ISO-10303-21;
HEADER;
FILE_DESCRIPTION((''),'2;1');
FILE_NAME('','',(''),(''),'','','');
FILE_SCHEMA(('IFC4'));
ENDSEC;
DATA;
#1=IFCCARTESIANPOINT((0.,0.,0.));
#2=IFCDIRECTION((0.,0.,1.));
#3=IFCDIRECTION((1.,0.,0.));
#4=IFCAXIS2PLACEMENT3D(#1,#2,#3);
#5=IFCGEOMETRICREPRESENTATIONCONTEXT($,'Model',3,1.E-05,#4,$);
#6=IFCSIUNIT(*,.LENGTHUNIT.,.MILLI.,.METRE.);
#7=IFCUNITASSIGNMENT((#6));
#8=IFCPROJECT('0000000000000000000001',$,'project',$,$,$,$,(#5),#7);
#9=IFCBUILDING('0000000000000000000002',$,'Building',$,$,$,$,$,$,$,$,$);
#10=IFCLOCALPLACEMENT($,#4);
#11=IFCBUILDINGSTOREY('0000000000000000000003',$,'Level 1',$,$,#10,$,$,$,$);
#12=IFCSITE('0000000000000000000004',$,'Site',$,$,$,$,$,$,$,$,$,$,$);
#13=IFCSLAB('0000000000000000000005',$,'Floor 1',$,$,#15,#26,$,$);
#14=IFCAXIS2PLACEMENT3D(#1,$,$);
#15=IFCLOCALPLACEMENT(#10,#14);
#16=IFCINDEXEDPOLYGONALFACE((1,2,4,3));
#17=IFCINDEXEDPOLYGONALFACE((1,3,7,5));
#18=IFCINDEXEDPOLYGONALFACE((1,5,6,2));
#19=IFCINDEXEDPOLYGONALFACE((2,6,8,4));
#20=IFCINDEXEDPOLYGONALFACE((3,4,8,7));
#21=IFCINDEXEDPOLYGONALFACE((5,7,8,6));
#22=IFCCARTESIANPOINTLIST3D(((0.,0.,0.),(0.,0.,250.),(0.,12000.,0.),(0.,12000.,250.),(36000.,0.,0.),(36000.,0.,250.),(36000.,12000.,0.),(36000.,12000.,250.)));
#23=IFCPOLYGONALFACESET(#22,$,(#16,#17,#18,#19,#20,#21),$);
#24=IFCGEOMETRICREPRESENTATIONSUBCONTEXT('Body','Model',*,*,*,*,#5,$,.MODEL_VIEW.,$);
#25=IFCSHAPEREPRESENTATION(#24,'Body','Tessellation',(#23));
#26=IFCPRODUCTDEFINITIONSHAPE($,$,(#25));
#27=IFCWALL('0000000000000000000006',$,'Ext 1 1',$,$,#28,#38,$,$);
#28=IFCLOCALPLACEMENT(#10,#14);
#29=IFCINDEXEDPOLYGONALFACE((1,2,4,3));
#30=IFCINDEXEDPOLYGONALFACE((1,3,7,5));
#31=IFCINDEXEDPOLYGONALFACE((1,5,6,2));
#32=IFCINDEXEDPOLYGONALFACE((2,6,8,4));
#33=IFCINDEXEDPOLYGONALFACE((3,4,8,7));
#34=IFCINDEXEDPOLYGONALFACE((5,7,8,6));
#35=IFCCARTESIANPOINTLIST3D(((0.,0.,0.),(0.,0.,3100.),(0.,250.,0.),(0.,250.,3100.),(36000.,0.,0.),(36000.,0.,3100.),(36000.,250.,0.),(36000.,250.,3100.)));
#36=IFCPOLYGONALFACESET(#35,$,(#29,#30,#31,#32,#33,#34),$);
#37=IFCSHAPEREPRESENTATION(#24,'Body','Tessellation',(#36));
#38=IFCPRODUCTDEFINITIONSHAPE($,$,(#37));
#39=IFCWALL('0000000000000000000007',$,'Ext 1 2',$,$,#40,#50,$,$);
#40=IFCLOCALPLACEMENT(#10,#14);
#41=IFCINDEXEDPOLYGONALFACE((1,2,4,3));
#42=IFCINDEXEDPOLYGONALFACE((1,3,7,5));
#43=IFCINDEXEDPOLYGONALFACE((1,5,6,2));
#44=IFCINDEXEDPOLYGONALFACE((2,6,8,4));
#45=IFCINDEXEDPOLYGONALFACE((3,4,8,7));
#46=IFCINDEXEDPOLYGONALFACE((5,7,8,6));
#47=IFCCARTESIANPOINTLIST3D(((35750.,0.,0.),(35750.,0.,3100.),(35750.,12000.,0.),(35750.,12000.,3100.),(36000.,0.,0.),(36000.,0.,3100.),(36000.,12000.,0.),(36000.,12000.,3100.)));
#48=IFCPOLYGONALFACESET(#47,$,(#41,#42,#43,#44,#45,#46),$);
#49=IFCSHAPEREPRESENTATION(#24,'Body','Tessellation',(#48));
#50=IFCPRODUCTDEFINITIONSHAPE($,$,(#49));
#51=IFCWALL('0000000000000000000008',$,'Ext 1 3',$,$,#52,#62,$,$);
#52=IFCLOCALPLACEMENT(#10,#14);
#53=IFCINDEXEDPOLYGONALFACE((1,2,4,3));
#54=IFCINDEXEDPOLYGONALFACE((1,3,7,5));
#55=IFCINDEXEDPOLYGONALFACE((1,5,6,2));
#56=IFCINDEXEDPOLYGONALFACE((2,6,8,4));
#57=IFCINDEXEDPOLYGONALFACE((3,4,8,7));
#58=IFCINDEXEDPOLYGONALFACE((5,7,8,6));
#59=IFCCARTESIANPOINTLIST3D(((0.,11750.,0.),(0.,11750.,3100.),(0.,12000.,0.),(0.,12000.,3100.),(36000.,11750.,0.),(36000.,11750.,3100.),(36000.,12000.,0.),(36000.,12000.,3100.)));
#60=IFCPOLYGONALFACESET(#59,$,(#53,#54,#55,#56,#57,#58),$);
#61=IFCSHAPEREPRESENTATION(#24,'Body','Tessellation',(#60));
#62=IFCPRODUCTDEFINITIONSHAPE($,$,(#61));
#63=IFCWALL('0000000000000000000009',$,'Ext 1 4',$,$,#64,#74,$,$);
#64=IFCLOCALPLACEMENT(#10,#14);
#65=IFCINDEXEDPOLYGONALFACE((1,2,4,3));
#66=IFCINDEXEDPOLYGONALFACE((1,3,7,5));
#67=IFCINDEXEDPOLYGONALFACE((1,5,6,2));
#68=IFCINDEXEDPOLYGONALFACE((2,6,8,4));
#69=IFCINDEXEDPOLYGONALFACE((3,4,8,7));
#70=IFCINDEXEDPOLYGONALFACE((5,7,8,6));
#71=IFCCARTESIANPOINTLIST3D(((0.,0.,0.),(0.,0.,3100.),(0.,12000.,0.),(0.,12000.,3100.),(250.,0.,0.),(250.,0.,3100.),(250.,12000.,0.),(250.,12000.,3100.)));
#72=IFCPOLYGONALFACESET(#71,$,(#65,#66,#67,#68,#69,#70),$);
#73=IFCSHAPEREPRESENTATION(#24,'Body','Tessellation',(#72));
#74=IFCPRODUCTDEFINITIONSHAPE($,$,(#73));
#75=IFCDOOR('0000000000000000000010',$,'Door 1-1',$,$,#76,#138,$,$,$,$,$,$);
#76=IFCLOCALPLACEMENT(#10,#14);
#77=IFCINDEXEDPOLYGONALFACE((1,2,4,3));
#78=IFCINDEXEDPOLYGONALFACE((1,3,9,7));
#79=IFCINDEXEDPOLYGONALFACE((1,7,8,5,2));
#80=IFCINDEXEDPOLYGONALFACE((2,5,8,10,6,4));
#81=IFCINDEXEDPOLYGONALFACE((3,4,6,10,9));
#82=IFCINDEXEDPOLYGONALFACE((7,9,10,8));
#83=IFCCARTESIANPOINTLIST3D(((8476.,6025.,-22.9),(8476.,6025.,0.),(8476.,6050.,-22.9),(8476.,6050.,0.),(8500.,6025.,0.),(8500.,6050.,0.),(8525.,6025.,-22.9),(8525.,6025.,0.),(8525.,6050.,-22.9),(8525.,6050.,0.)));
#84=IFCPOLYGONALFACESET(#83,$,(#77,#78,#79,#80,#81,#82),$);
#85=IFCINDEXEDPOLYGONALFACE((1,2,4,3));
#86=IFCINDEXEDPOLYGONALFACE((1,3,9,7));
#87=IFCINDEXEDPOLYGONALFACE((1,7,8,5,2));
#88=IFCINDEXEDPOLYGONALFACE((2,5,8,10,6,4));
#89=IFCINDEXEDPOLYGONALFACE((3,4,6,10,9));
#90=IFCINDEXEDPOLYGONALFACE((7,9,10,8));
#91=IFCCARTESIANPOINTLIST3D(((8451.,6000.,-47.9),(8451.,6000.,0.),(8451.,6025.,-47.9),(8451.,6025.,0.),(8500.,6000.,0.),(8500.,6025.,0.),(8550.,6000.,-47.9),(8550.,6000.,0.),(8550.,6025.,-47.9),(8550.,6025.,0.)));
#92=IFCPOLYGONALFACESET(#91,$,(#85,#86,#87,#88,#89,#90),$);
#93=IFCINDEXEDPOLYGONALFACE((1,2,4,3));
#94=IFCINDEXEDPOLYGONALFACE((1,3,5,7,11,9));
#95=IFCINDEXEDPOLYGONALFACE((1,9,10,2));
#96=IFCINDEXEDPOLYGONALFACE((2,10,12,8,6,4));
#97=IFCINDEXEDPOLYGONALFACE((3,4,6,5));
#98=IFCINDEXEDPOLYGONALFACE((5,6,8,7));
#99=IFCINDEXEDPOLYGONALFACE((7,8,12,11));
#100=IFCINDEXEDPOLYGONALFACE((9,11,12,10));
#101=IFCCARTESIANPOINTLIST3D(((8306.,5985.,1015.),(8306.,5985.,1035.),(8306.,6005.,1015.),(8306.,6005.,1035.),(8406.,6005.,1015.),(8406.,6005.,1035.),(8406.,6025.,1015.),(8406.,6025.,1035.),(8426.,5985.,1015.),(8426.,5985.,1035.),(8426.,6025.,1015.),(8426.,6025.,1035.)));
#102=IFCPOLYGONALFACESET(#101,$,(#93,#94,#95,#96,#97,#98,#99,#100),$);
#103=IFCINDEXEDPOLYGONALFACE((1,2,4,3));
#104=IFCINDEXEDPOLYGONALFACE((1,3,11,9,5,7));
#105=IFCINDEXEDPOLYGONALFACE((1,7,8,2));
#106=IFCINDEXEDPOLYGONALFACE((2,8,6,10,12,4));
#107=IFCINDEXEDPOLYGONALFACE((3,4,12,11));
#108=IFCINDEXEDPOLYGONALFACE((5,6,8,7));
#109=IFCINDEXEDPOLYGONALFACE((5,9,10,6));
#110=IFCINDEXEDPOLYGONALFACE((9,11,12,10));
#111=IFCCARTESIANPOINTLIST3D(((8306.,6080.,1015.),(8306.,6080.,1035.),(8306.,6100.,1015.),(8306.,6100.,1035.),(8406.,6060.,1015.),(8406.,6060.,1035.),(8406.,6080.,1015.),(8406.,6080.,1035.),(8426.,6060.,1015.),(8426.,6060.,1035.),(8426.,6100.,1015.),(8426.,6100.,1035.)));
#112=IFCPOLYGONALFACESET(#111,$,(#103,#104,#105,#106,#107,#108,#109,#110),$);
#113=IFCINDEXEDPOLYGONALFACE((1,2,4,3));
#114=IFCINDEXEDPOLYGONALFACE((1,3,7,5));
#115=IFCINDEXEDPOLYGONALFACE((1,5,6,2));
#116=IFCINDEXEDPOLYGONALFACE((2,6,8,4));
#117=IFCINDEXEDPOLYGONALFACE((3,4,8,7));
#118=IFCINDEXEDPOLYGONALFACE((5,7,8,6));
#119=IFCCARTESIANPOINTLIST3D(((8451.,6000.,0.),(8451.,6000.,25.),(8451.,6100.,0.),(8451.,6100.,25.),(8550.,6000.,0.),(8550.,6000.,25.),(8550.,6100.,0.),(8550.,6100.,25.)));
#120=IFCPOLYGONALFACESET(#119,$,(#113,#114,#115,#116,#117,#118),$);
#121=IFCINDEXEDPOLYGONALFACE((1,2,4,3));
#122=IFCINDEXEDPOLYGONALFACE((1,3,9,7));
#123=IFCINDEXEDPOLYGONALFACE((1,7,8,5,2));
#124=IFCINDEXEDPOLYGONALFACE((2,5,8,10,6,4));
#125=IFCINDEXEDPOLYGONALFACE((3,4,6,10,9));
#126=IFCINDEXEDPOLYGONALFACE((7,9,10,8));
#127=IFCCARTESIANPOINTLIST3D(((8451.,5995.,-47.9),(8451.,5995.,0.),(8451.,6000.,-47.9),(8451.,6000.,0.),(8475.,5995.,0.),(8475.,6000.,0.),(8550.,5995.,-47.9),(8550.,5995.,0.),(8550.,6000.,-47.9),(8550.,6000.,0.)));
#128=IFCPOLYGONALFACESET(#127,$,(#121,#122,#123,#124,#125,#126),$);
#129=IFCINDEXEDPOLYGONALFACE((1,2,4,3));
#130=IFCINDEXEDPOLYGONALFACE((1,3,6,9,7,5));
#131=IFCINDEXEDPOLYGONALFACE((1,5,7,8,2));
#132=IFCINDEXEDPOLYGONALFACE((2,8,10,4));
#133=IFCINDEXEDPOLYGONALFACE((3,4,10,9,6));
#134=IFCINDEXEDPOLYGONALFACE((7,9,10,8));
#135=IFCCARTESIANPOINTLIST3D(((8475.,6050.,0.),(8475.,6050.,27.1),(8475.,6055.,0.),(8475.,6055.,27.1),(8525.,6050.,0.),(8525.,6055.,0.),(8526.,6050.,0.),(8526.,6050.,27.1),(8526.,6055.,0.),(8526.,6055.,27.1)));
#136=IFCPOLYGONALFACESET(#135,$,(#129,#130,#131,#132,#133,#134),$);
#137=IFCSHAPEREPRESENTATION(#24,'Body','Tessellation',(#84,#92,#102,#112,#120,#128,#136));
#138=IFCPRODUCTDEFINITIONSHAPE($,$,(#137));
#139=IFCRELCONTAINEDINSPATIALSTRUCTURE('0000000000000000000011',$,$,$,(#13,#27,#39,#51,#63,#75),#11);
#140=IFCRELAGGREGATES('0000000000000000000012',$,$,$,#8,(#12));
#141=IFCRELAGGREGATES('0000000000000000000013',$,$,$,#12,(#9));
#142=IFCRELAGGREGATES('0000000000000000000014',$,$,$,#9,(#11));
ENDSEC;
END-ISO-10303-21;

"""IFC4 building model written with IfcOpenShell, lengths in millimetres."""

from ifc_helpers import new_model, si_unit, frame, origin_with_axes, place, context, subcontext, project, spatial, line, indexed_curve, outline, extrude, element, save


model = new_model("IFC4")

# Units and contexts
model_context = context("Model", 3, precision=1e-05, world=origin_with_axes())
body_context = subcontext(model_context, "Body", "Model", "MODEL_VIEW")
ifc_project = project(units=[si_unit("LENGTHUNIT", "METRE", prefix="MILLI")], contexts=[model_context])

# Site, building, storey
site = spatial("IfcSite", under=ifc_project, Name="Site")
building = spatial("IfcBuilding", under=site, Name="Building")
storey_placement = place(None, origin_with_axes())
storey = spatial("IfcBuildingStorey", under=building, at=storey_placement, Name="Level 1")

# Slab
slab_placement = place(storey_placement, origin_with_axes())
element("IfcSlab", 1, at=slab_placement, inside=storey, Name="Floor 1", context=body_context, shape_type="SweptSolid", body=[
    extrude(outline(indexed_curve([(0.0, 0.0), (36000.0, 0.0), (36000.0, 12000.0), (0.0, 12000.0), (0.0, 0.0)])), None, (0.0, 0.0, 1.0), 250.0),
])

# Walls
wall_1_placement = place(storey_placement, origin_with_axes())
element("IfcWall", 2, at=wall_1_placement, inside=storey, Name="Ext 1 1", context=body_context, shape_type="SweptSolid", body=[
    extrude(outline(indexed_curve([(0.0, 0.0), (0.0, 250.0), (36000.0, 250.0), (36000.0, 0.0), (0.0, 0.0)], self_intersect=False)), origin_with_axes(), (0.0, 0.0, 1.0), 3100.0),
])
wall_2_placement = place(storey_placement, frame((36000.0, 0.0, 0.0), z_axis=(0.0, 0.0, 1.0), x_axis=(0.0, 1.0, 0.0)))
element("IfcWall", 3, at=wall_2_placement, inside=storey, Name="Ext 1 2", context=body_context, shape_type="SweptSolid", body=[
    extrude(outline(indexed_curve([(0.0, 0.0), (0.0, 250.0), (12000.0, 250.0), (12000.0, 0.0), (0.0, 0.0)], self_intersect=False)), origin_with_axes(), (0.0, 0.0, 1.0), 3100.0),
])
wall_3_placement = place(storey_placement, frame((36000.0, 12000.0, 0.0), z_axis=(0.0, 0.0, 1.0), x_axis=(-1.0, 0.0, 0.0)))
element("IfcWall", 4, at=wall_3_placement, inside=storey, Name="Ext 1 3", context=body_context, shape_type="SweptSolid", body=[
    extrude(outline(indexed_curve([(0.0, 0.0), (0.0, 250.0), (36000.0, 250.0), (36000.0, 0.0), (0.0, 0.0)], self_intersect=False)), origin_with_axes(), (0.0, 0.0, 1.0), 3100.0),
])
wall_4_placement = place(storey_placement, frame((0.0, 12000.0, 0.0), z_axis=(0.0, 0.0, 1.0), x_axis=(0.0, -1.0, 0.0)))
element("IfcWall", 5, at=wall_4_placement, inside=storey, Name="Ext 1 4", context=body_context, shape_type="SweptSolid", body=[
    extrude(outline(indexed_curve([(0.0, 0.0), (0.0, 250.0), (12000.0, 250.0), (12000.0, 0.0), (0.0, 0.0)], self_intersect=False)), origin_with_axes(), (0.0, 0.0, 1.0), 3100.0),
])

# Door
door_1_placement = place(storey_placement, frame((8500.0, 6000.0, 0.0), z_axis=(0.0, 0.0, 1.0), x_axis=(1.0, 0.0, 0.0)))
element("IfcDoor", 6, at=door_1_placement, inside=storey, Name="Door 1-1", context=body_context, shape_type="SweptSolid", body=[
    extrude(outline(indexed_curve([(0.0, 0.0), (0.0, 2.1), (1.0, 2.1), (1.0, 0.0), (-24.0, 0.0), (-24.0, -22.9), (25.0, -22.9), (25.0, 0.0)], segments=[line(1, 2, 3, 4, 5, 6, 7, 8, 1)])), frame((0.0, 25.0, 0.0), z_axis=(0.0, -1.0, 0.0), x_axis=(1.0, 0.0, 0.0)), (0.0, 0.0, -1.0), 25.0),
    extrude(outline(indexed_curve([(0.0, 0.0), (0.0, 2.1), (1.0, 2.1), (1.0, 0.0), (-49.0, 0.0), (-49.0, -47.9), (50.0, -47.9), (50.0, 0.0)], segments=[line(1, 2, 3, 4, 5, 6, 7, 8, 1)])), frame((0.0, 0.0, 0.0), z_axis=(0.0, -1.0, 0.0), x_axis=(1.0, 0.0, 0.0)), (0.0, 0.0, -1.0), 25.0),
    extrude(outline(indexed_curve([(0.0, 0.0), (-49.0, 0.0), (-49.0, 35.0), (0.0, 35.0)], segments=[line(1, 2, 3, 4, 1)])), frame((25.0, 25.0, 25.0), z_axis=(0.0, 0.0, 1.0), x_axis=(1.0, 0.0, 0.0)), (0.0, 0.0, 1.0), -47.9),
    extrude(outline(indexed_curve([(0.0, 0.0), (0.0, -40.0), (-120.0, -40.0), (-120.0, -20.0), (-20.0, -20.0), (-20.0, 0.0)], segments=[line(1, 2, 3, 4, 5, 6, 1)])), frame((-74.0, 25.0, 1015.0), z_axis=(0.0, 0.0, 1.0), x_axis=(1.0, 0.0, 0.0)), (0.0, 0.0, 1.0), 20.0),
    extrude(outline(indexed_curve([(0.0, 0.0), (0.0, 40.0), (-120.0, 40.0), (-120.0, 20.0), (-20.0, 20.0), (-20.0, 0.0)], segments=[line(1, 2, 3, 4, 5, 6, 1)])), frame((-74.0, 60.0, 1015.0), z_axis=(0.0, 0.0, 1.0), x_axis=(1.0, 0.0, 0.0)), (0.0, 0.0, 1.0), 20.0),
    extrude(outline(indexed_curve([(0.0, 0.0), (-99.0, 0.0), (-99.0, 100.0), (0.0, 100.0)], segments=[line(1, 2, 3, 4, 1)])), frame((50.0, 0.0, 0.0), z_axis=(0.0, 0.0, 1.0), x_axis=(1.0, 0.0, 0.0)), (0.0, 0.0, 1.0), 25.0),
    extrude(outline(indexed_curve([(0.0, 0.0), (0.0, 27.1), (51.0, 27.1), (51.0, 0.0), (-24.0, 0.0), (-24.0, -47.9), (75.0, -47.9), (75.0, 0.0)], segments=[line(1, 2, 3, 4, 5, 6, 7, 8, 1)])), frame((-25.0, -5.0, 0.0), z_axis=(0.0, -1.0, 0.0), x_axis=(1.0, 0.0, 0.0)), (0.0, 0.0, -1.0), 5.0),
    extrude(outline(indexed_curve([(0.0, 0.0), (0.0, 27.1), (51.0, 27.1), (51.0, 0.0), (1.0, 0.0), (1.0, -22.9), (50.0, -22.9), (50.0, 0.0)], segments=[line(1, 2, 3, 4, 5, 6, 7, 8, 1)])), frame((-25.0, 50.0, 0.0), z_axis=(0.0, -1.0, 0.0), x_axis=(1.0, 0.0, 0.0)), (0.0, 0.0, -1.0), 5.0),
])

save(model, "model.ifc")
